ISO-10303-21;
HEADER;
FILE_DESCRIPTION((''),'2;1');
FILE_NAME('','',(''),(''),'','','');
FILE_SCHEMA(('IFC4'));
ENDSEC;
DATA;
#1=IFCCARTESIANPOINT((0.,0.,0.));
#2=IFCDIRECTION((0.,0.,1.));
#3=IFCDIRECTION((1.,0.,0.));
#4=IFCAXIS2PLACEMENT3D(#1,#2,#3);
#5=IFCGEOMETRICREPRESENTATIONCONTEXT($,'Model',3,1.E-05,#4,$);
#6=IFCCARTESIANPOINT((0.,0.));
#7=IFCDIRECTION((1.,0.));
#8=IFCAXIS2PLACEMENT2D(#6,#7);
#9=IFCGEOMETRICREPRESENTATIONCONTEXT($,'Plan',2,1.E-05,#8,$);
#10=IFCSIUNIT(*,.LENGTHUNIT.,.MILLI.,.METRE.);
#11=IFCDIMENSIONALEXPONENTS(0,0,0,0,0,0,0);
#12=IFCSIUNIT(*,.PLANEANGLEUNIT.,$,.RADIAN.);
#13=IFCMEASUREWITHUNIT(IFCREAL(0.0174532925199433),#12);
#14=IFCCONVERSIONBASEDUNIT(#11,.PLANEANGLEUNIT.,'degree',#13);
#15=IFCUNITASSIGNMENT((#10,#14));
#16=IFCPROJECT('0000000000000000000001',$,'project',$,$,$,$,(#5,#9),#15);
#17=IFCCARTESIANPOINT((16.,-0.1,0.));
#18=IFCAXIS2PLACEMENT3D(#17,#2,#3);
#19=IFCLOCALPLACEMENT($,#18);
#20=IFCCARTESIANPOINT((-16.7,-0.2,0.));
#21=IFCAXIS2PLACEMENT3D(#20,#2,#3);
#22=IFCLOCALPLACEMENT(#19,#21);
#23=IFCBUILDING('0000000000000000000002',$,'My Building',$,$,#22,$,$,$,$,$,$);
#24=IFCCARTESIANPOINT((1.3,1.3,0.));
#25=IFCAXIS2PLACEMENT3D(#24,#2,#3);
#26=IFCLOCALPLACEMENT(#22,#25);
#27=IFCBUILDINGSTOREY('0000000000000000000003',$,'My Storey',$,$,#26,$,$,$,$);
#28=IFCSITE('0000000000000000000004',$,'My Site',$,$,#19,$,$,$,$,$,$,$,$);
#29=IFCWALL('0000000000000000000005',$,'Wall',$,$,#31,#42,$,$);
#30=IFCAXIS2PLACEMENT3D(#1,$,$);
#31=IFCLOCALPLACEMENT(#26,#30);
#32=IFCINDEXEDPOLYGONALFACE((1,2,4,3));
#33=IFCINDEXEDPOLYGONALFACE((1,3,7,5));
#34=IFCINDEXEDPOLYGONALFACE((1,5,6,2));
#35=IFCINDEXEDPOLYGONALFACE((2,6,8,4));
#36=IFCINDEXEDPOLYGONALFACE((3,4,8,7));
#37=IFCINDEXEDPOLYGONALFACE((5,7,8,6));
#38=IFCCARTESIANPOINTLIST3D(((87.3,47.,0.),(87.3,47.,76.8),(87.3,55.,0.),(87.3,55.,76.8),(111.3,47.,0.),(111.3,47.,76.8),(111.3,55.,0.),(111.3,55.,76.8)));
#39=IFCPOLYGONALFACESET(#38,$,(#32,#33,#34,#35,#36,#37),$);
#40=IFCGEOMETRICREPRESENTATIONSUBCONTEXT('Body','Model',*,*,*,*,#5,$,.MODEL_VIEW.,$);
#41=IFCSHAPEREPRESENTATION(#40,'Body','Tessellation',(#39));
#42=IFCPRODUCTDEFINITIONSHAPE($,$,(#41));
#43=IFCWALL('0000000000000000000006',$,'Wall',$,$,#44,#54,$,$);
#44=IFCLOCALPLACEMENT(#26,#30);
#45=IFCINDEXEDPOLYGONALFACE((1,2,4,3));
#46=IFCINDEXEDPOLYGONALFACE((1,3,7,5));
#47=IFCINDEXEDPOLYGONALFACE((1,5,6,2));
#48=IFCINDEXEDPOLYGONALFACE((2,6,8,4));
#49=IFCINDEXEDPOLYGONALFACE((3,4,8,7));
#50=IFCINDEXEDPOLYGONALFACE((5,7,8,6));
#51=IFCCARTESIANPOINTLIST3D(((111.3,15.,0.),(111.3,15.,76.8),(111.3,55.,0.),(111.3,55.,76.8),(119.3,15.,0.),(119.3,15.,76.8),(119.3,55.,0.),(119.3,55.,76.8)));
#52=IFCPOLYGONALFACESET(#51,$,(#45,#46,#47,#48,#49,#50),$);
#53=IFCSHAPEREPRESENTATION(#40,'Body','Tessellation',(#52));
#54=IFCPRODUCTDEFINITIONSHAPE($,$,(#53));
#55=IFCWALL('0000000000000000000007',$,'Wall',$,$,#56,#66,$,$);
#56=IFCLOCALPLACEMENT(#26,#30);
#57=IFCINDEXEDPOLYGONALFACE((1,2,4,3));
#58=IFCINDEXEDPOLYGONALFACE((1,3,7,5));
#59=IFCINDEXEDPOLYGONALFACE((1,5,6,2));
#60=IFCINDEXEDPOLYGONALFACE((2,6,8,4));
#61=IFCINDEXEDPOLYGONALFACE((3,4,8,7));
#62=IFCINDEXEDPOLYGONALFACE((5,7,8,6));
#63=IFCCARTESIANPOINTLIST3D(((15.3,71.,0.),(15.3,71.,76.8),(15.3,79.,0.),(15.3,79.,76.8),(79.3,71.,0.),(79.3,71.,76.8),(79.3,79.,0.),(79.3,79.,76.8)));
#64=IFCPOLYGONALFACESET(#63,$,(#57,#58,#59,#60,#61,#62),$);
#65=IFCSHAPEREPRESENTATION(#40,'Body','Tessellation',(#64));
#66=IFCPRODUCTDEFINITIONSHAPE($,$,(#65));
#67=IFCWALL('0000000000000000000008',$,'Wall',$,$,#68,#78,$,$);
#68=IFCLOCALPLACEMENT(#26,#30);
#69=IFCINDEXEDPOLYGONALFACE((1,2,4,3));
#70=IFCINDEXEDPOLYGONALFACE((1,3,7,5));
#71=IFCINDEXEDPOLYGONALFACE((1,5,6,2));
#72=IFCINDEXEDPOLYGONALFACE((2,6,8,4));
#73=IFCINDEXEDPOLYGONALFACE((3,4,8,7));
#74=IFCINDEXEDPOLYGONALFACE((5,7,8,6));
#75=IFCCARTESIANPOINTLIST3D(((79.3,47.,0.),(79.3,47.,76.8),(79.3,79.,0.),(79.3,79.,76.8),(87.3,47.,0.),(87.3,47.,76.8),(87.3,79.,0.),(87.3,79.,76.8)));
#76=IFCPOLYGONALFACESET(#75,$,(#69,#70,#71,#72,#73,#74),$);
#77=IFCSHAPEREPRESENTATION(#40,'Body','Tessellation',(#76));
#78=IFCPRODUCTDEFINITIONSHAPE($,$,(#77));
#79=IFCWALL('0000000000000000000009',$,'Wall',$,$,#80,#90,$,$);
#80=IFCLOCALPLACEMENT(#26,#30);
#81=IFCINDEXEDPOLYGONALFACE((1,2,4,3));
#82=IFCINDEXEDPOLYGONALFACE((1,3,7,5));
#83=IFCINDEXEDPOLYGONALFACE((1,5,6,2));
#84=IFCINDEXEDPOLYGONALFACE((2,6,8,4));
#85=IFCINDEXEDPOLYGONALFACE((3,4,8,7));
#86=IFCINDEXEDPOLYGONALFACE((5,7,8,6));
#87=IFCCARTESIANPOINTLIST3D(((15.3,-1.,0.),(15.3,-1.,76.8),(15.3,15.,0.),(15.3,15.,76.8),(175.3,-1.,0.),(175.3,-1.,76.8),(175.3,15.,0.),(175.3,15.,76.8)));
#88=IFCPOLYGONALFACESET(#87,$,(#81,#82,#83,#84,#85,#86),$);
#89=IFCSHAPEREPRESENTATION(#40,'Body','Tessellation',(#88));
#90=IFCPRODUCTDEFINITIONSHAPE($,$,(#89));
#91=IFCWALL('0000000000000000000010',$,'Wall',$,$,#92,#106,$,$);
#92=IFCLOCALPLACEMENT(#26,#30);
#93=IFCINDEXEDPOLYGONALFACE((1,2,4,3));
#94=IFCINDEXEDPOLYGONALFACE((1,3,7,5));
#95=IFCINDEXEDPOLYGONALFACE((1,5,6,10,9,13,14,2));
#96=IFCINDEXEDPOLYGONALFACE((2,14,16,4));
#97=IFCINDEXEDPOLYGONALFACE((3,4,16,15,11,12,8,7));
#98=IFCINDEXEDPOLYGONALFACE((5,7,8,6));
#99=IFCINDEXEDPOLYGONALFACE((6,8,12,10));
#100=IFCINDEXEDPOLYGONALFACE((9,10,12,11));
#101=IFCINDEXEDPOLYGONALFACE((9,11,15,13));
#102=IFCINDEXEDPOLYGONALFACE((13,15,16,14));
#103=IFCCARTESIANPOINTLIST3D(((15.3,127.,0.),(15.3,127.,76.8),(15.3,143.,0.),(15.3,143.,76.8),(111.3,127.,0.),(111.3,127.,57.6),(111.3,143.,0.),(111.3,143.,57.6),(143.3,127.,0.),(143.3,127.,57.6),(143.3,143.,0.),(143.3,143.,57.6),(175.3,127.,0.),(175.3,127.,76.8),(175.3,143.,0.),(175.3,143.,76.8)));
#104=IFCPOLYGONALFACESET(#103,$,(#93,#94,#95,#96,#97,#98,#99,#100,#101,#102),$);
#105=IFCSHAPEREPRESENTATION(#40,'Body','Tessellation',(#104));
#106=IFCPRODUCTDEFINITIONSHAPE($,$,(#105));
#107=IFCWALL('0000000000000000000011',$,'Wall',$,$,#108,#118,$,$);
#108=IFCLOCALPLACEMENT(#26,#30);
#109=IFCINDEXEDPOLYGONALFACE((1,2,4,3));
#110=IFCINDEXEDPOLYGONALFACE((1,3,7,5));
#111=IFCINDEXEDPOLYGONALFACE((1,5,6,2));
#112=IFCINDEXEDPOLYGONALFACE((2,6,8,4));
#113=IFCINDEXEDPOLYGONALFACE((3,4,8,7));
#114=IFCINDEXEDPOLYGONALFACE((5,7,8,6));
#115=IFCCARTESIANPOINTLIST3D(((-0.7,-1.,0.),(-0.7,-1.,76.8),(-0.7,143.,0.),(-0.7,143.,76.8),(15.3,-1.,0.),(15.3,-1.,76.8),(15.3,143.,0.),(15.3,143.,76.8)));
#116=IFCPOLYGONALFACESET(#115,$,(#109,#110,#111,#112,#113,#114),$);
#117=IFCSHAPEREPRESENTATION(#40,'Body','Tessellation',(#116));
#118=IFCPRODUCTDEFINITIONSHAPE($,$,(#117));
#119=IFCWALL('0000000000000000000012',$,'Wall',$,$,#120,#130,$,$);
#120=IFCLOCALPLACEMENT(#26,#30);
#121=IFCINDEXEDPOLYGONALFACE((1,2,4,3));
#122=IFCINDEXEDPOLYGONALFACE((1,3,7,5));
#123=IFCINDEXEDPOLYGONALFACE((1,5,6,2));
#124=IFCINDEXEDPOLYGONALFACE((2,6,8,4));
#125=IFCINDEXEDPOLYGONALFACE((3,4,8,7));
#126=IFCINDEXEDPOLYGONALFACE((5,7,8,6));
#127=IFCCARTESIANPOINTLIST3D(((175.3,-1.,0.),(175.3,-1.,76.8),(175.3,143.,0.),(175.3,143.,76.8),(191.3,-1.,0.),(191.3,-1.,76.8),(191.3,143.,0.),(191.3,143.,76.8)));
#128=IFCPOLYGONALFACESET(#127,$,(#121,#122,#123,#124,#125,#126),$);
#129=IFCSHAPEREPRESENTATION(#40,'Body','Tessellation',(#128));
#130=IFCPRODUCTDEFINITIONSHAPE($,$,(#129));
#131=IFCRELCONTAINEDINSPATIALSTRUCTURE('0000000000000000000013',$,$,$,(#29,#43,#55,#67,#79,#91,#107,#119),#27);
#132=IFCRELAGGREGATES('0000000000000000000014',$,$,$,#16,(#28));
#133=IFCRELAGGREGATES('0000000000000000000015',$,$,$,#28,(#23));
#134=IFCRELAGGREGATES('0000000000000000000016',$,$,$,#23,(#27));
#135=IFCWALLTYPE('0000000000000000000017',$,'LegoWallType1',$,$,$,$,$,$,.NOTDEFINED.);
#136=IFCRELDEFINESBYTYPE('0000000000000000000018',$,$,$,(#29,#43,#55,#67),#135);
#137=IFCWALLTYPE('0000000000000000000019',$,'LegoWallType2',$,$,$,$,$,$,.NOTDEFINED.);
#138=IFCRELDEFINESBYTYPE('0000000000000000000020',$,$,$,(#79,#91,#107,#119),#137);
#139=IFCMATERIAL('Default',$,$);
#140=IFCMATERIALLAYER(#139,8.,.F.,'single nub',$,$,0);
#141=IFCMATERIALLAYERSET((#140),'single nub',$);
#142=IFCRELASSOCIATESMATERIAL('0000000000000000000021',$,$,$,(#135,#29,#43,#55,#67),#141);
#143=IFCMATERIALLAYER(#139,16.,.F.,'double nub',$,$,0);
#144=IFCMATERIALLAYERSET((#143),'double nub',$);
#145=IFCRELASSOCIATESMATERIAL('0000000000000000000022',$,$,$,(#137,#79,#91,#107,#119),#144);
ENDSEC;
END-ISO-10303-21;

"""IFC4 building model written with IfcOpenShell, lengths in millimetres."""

from ifc_helpers import new_model, entity, si_unit, converted_unit, frame, origin_with_axes, origin_2d_with_axis, place, context, subcontext, project, spatial, line, indexed_curve, outline, extrude, source, transform, mapped, material, layer, layer_set, layer_usage, type_object, element, save


model = new_model("IFC4")

# Units and contexts
model_context = context("Model", 3, precision=1e-05, world=origin_with_axes())
plan_context = context("Plan", 2, precision=1e-05, world=origin_2d_with_axis())
body_context = subcontext(model_context, "Body", "Model", "MODEL_VIEW")
ifc_project = project(units=[si_unit("LENGTHUNIT", "METRE", prefix="MILLI"), converted_unit("PLANEANGLEUNIT", "degree", entity("IfcReal", 0.0174532925199433), si_unit("PLANEANGLEUNIT", "RADIAN"), dimensions=[0, 0, 0, 0, 0, 0, 0])], contexts=[model_context, plan_context])

# Site, building, storey
site_placement = place(None, frame((16.0, -0.1, 0.0), z_axis=(0.0, 0.0, 1.0), x_axis=(1.0, 0.0, 0.0)))
site = spatial("IfcSite", under=ifc_project, at=site_placement, Name="My Site")
building_placement = place(site_placement, frame((-16.7, -0.2, 0.0), z_axis=(0.0, 0.0, 1.0), x_axis=(1.0, 0.0, 0.0)))
building = spatial("IfcBuilding", under=site, at=building_placement, Name="My Building")
storey_placement = place(building_placement, frame((1.3, 1.3, 0.0), z_axis=(0.0, 0.0, 1.0), x_axis=(1.0, 0.0, 0.0)))
storey = spatial("IfcBuildingStorey", under=building, at=storey_placement, Name="My Storey")

# Walls
ifc_material = material(Name="Default")
ifc_layer_1 = layer(ifc_material, 8.0, ventilated=False, Name="single nub", Priority=0)
ifc_layer_set_1 = layer_set([ifc_layer_1], Name="single nub")
ifc_layer_usage_1 = layer_usage(ifc_layer_set_1, "AXIS2", "POSITIVE", 0.0)
wall_type_1 = type_object("IfcWallType", Name="LegoWallType1", PredefinedType="NOTDEFINED", material=ifc_layer_set_1)
wall_1_placement = place(storey_placement, frame((87.3, 47.0, 0.0), z_axis=(0.0, 0.0, 1.0), x_axis=(1.0, 0.0, 0.0)))
element("IfcWall", 1, at=wall_1_placement, inside=storey, type_object=wall_type_1, material=ifc_layer_usage_1, Name="Wall", context=body_context, shape_type="SweptSolid", body=[
    extrude(outline(indexed_curve([(0.0, 0.0), (0.0, 8.0), (24.0, 8.0), (24.0, 0.0), (0.0, 0.0)], self_intersect=False)), origin_with_axes(), (0.0, 0.0, 1.0), 76.8),
])
ifc_layer_usage_2 = layer_usage(ifc_layer_set_1, "AXIS2", "POSITIVE", 0.0)
wall_2_placement = place(storey_placement, frame((119.3, 15.0, 0.0), z_axis=(0.0, 0.0, 1.0), x_axis=(0.0, 1.0, 0.0)))
element("IfcWall", 2, at=wall_2_placement, inside=storey, type_object=wall_type_1, material=ifc_layer_usage_2, Name="Wall", context=body_context, shape_type="SweptSolid", body=[
    extrude(outline(indexed_curve([(0.0, 0.0), (0.0, 8.0), (40.0, 8.0), (40.0, 0.0), (0.0, 0.0)], self_intersect=False)), origin_with_axes(), (0.0, 0.0, 1.0), 76.8),
])
ifc_layer_usage_3 = layer_usage(ifc_layer_set_1, "AXIS2", "POSITIVE", 0.0)
wall_3_placement = place(storey_placement, frame((15.3, 71.0, 0.0), z_axis=(0.0, 0.0, 1.0), x_axis=(1.0, 0.0, 0.0)))
element("IfcWall", 3, at=wall_3_placement, inside=storey, type_object=wall_type_1, material=ifc_layer_usage_3, Name="Wall", context=body_context, shape_type="SweptSolid", body=[
    extrude(outline(indexed_curve([(0.0, 0.0), (0.0, 8.0), (64.0, 8.0), (64.0, 0.0), (0.0, 0.0)], self_intersect=False)), origin_with_axes(), (0.0, 0.0, 1.0), 76.8),
])
ifc_layer_usage_4 = layer_usage(ifc_layer_set_1, "AXIS2", "POSITIVE", 0.0)
wall_4_placement = place(storey_placement, frame((87.3, 47.0, 0.0), z_axis=(0.0, 0.0, 1.0), x_axis=(0.0, 1.0, 0.0)))
element("IfcWall", 4, at=wall_4_placement, inside=storey, type_object=wall_type_1, material=ifc_layer_usage_4, Name="Wall", context=body_context, shape_type="SweptSolid", body=[
    extrude(outline(indexed_curve([(0.0, 0.0), (0.0, 8.0), (32.0, 8.0), (32.0, 0.0), (0.0, 0.0)], self_intersect=False)), origin_with_axes(), (0.0, 0.0, 1.0), 76.8),
])
ifc_layer_2 = layer(ifc_material, 16.0, ventilated=False, Name="double nub", Priority=0)
ifc_layer_set_2 = layer_set([ifc_layer_2], Name="double nub")
ifc_layer_usage_5 = layer_usage(ifc_layer_set_2, "AXIS2", "POSITIVE", 0.0)
wall_type_2 = type_object("IfcWallType", Name="LegoWallType2", PredefinedType="NOTDEFINED", material=ifc_layer_set_2)
wall_5_placement = place(storey_placement, frame((15.3, -1.0, 0.0), z_axis=(0.0, 0.0, 1.0), x_axis=(1.0, 0.0, 0.0)))
element("IfcWall", 5, at=wall_5_placement, inside=storey, type_object=wall_type_2, material=ifc_layer_usage_5, Name="Wall", context=body_context, shape_type="SweptSolid", body=[
    extrude(outline(indexed_curve([(0.0, 0.0), (0.0, 16.0), (160.0, 16.0), (160.0, 0.0), (0.0, 0.0)], self_intersect=False)), origin_with_axes(), (0.0, 0.0, 1.0), 76.8),
])

# Wall, opening
ifc_layer_usage_6 = layer_usage(ifc_layer_set_2, "AXIS2", "POSITIVE", 0.0)
wall_6_placement = place(storey_placement, frame((15.3, 127.0, 0.0), z_axis=(0.0, 0.0, 1.0), x_axis=(1.0, 0.0, 0.0)))
wall_6 = element("IfcWall", 6, at=wall_6_placement, inside=storey, type_object=wall_type_2, material=ifc_layer_usage_6, Name="Wall", context=body_context, shape_type="SweptSolid", body=[
    extrude(outline(indexed_curve([(0.0, 0.0), (0.0, 16.0), (160.0, 16.0), (160.0, 0.0), (0.0, 0.0)], self_intersect=False)), origin_with_axes(), (0.0, 0.0, 1.0), 76.8),
])
shared_shape = source(origin_with_axes(), body_context, "Body", "SweptSolid", [
    extrude(outline(indexed_curve([(0.0, 0.0), (32.0, 0.0), (32.0, 57.6), (0.0, 57.6)], segments=[line(1, 2, 3, 4, 1)])), frame((0.0, -600.0, 0.0), z_axis=(0.0, -1.0, 0.0), x_axis=(1.0, 0.0, 0.0)), (0.0, 0.0, -1.0), 1200.0),
])
opening_placement = place(wall_6_placement, frame((96.0, 0.0, 0.0), z_axis=(0.0, 0.0, 1.0), x_axis=(1.0, 0.0, 0.0)))
element("IfcOpeningElement", 7, at=opening_placement, cuts=wall_6, PredefinedType="OPENING", context=body_context, shape_type="MappedRepresentation", body=[
    mapped(shared_shape, transform((0.0, 0.0, 0.0), x_axis=(1.0, 0.0, 0.0), y_axis=(0.0, 1.0, 0.0), z_axis=(0.0, 0.0, 1.0), scale=1.0)),
])

# Walls
ifc_layer_usage_7 = layer_usage(ifc_layer_set_2, "AXIS2", "POSITIVE", 0.0)
wall_7_placement = place(storey_placement, frame((15.3, -1.0, 0.0), z_axis=(0.0, 0.0, 1.0), x_axis=(0.0, 1.0, 0.0)))
element("IfcWall", 8, at=wall_7_placement, inside=storey, type_object=wall_type_2, material=ifc_layer_usage_7, Name="Wall", context=body_context, shape_type="SweptSolid", body=[
    extrude(outline(indexed_curve([(0.0, 0.0), (0.0, 16.0), (144.0, 16.0), (144.0, 0.0), (0.0, 0.0)], self_intersect=False)), origin_with_axes(), (0.0, 0.0, 1.0), 76.8),
])
ifc_layer_usage_8 = layer_usage(ifc_layer_set_2, "AXIS2", "POSITIVE", 0.0)
wall_8_placement = place(storey_placement, frame((191.3, -1.0, 0.0), z_axis=(0.0, 0.0, 1.0), x_axis=(0.0, 1.0, 0.0)))
element("IfcWall", 9, at=wall_8_placement, inside=storey, type_object=wall_type_2, material=ifc_layer_usage_8, Name="Wall", context=body_context, shape_type="SweptSolid", body=[
    extrude(outline(indexed_curve([(0.0, 0.0), (0.0, 16.0), (144.0, 16.0), (144.0, 0.0), (0.0, 0.0)], self_intersect=False)), origin_with_axes(), (0.0, 0.0, 1.0), 76.8),
])

save(model, "model.ifc")
